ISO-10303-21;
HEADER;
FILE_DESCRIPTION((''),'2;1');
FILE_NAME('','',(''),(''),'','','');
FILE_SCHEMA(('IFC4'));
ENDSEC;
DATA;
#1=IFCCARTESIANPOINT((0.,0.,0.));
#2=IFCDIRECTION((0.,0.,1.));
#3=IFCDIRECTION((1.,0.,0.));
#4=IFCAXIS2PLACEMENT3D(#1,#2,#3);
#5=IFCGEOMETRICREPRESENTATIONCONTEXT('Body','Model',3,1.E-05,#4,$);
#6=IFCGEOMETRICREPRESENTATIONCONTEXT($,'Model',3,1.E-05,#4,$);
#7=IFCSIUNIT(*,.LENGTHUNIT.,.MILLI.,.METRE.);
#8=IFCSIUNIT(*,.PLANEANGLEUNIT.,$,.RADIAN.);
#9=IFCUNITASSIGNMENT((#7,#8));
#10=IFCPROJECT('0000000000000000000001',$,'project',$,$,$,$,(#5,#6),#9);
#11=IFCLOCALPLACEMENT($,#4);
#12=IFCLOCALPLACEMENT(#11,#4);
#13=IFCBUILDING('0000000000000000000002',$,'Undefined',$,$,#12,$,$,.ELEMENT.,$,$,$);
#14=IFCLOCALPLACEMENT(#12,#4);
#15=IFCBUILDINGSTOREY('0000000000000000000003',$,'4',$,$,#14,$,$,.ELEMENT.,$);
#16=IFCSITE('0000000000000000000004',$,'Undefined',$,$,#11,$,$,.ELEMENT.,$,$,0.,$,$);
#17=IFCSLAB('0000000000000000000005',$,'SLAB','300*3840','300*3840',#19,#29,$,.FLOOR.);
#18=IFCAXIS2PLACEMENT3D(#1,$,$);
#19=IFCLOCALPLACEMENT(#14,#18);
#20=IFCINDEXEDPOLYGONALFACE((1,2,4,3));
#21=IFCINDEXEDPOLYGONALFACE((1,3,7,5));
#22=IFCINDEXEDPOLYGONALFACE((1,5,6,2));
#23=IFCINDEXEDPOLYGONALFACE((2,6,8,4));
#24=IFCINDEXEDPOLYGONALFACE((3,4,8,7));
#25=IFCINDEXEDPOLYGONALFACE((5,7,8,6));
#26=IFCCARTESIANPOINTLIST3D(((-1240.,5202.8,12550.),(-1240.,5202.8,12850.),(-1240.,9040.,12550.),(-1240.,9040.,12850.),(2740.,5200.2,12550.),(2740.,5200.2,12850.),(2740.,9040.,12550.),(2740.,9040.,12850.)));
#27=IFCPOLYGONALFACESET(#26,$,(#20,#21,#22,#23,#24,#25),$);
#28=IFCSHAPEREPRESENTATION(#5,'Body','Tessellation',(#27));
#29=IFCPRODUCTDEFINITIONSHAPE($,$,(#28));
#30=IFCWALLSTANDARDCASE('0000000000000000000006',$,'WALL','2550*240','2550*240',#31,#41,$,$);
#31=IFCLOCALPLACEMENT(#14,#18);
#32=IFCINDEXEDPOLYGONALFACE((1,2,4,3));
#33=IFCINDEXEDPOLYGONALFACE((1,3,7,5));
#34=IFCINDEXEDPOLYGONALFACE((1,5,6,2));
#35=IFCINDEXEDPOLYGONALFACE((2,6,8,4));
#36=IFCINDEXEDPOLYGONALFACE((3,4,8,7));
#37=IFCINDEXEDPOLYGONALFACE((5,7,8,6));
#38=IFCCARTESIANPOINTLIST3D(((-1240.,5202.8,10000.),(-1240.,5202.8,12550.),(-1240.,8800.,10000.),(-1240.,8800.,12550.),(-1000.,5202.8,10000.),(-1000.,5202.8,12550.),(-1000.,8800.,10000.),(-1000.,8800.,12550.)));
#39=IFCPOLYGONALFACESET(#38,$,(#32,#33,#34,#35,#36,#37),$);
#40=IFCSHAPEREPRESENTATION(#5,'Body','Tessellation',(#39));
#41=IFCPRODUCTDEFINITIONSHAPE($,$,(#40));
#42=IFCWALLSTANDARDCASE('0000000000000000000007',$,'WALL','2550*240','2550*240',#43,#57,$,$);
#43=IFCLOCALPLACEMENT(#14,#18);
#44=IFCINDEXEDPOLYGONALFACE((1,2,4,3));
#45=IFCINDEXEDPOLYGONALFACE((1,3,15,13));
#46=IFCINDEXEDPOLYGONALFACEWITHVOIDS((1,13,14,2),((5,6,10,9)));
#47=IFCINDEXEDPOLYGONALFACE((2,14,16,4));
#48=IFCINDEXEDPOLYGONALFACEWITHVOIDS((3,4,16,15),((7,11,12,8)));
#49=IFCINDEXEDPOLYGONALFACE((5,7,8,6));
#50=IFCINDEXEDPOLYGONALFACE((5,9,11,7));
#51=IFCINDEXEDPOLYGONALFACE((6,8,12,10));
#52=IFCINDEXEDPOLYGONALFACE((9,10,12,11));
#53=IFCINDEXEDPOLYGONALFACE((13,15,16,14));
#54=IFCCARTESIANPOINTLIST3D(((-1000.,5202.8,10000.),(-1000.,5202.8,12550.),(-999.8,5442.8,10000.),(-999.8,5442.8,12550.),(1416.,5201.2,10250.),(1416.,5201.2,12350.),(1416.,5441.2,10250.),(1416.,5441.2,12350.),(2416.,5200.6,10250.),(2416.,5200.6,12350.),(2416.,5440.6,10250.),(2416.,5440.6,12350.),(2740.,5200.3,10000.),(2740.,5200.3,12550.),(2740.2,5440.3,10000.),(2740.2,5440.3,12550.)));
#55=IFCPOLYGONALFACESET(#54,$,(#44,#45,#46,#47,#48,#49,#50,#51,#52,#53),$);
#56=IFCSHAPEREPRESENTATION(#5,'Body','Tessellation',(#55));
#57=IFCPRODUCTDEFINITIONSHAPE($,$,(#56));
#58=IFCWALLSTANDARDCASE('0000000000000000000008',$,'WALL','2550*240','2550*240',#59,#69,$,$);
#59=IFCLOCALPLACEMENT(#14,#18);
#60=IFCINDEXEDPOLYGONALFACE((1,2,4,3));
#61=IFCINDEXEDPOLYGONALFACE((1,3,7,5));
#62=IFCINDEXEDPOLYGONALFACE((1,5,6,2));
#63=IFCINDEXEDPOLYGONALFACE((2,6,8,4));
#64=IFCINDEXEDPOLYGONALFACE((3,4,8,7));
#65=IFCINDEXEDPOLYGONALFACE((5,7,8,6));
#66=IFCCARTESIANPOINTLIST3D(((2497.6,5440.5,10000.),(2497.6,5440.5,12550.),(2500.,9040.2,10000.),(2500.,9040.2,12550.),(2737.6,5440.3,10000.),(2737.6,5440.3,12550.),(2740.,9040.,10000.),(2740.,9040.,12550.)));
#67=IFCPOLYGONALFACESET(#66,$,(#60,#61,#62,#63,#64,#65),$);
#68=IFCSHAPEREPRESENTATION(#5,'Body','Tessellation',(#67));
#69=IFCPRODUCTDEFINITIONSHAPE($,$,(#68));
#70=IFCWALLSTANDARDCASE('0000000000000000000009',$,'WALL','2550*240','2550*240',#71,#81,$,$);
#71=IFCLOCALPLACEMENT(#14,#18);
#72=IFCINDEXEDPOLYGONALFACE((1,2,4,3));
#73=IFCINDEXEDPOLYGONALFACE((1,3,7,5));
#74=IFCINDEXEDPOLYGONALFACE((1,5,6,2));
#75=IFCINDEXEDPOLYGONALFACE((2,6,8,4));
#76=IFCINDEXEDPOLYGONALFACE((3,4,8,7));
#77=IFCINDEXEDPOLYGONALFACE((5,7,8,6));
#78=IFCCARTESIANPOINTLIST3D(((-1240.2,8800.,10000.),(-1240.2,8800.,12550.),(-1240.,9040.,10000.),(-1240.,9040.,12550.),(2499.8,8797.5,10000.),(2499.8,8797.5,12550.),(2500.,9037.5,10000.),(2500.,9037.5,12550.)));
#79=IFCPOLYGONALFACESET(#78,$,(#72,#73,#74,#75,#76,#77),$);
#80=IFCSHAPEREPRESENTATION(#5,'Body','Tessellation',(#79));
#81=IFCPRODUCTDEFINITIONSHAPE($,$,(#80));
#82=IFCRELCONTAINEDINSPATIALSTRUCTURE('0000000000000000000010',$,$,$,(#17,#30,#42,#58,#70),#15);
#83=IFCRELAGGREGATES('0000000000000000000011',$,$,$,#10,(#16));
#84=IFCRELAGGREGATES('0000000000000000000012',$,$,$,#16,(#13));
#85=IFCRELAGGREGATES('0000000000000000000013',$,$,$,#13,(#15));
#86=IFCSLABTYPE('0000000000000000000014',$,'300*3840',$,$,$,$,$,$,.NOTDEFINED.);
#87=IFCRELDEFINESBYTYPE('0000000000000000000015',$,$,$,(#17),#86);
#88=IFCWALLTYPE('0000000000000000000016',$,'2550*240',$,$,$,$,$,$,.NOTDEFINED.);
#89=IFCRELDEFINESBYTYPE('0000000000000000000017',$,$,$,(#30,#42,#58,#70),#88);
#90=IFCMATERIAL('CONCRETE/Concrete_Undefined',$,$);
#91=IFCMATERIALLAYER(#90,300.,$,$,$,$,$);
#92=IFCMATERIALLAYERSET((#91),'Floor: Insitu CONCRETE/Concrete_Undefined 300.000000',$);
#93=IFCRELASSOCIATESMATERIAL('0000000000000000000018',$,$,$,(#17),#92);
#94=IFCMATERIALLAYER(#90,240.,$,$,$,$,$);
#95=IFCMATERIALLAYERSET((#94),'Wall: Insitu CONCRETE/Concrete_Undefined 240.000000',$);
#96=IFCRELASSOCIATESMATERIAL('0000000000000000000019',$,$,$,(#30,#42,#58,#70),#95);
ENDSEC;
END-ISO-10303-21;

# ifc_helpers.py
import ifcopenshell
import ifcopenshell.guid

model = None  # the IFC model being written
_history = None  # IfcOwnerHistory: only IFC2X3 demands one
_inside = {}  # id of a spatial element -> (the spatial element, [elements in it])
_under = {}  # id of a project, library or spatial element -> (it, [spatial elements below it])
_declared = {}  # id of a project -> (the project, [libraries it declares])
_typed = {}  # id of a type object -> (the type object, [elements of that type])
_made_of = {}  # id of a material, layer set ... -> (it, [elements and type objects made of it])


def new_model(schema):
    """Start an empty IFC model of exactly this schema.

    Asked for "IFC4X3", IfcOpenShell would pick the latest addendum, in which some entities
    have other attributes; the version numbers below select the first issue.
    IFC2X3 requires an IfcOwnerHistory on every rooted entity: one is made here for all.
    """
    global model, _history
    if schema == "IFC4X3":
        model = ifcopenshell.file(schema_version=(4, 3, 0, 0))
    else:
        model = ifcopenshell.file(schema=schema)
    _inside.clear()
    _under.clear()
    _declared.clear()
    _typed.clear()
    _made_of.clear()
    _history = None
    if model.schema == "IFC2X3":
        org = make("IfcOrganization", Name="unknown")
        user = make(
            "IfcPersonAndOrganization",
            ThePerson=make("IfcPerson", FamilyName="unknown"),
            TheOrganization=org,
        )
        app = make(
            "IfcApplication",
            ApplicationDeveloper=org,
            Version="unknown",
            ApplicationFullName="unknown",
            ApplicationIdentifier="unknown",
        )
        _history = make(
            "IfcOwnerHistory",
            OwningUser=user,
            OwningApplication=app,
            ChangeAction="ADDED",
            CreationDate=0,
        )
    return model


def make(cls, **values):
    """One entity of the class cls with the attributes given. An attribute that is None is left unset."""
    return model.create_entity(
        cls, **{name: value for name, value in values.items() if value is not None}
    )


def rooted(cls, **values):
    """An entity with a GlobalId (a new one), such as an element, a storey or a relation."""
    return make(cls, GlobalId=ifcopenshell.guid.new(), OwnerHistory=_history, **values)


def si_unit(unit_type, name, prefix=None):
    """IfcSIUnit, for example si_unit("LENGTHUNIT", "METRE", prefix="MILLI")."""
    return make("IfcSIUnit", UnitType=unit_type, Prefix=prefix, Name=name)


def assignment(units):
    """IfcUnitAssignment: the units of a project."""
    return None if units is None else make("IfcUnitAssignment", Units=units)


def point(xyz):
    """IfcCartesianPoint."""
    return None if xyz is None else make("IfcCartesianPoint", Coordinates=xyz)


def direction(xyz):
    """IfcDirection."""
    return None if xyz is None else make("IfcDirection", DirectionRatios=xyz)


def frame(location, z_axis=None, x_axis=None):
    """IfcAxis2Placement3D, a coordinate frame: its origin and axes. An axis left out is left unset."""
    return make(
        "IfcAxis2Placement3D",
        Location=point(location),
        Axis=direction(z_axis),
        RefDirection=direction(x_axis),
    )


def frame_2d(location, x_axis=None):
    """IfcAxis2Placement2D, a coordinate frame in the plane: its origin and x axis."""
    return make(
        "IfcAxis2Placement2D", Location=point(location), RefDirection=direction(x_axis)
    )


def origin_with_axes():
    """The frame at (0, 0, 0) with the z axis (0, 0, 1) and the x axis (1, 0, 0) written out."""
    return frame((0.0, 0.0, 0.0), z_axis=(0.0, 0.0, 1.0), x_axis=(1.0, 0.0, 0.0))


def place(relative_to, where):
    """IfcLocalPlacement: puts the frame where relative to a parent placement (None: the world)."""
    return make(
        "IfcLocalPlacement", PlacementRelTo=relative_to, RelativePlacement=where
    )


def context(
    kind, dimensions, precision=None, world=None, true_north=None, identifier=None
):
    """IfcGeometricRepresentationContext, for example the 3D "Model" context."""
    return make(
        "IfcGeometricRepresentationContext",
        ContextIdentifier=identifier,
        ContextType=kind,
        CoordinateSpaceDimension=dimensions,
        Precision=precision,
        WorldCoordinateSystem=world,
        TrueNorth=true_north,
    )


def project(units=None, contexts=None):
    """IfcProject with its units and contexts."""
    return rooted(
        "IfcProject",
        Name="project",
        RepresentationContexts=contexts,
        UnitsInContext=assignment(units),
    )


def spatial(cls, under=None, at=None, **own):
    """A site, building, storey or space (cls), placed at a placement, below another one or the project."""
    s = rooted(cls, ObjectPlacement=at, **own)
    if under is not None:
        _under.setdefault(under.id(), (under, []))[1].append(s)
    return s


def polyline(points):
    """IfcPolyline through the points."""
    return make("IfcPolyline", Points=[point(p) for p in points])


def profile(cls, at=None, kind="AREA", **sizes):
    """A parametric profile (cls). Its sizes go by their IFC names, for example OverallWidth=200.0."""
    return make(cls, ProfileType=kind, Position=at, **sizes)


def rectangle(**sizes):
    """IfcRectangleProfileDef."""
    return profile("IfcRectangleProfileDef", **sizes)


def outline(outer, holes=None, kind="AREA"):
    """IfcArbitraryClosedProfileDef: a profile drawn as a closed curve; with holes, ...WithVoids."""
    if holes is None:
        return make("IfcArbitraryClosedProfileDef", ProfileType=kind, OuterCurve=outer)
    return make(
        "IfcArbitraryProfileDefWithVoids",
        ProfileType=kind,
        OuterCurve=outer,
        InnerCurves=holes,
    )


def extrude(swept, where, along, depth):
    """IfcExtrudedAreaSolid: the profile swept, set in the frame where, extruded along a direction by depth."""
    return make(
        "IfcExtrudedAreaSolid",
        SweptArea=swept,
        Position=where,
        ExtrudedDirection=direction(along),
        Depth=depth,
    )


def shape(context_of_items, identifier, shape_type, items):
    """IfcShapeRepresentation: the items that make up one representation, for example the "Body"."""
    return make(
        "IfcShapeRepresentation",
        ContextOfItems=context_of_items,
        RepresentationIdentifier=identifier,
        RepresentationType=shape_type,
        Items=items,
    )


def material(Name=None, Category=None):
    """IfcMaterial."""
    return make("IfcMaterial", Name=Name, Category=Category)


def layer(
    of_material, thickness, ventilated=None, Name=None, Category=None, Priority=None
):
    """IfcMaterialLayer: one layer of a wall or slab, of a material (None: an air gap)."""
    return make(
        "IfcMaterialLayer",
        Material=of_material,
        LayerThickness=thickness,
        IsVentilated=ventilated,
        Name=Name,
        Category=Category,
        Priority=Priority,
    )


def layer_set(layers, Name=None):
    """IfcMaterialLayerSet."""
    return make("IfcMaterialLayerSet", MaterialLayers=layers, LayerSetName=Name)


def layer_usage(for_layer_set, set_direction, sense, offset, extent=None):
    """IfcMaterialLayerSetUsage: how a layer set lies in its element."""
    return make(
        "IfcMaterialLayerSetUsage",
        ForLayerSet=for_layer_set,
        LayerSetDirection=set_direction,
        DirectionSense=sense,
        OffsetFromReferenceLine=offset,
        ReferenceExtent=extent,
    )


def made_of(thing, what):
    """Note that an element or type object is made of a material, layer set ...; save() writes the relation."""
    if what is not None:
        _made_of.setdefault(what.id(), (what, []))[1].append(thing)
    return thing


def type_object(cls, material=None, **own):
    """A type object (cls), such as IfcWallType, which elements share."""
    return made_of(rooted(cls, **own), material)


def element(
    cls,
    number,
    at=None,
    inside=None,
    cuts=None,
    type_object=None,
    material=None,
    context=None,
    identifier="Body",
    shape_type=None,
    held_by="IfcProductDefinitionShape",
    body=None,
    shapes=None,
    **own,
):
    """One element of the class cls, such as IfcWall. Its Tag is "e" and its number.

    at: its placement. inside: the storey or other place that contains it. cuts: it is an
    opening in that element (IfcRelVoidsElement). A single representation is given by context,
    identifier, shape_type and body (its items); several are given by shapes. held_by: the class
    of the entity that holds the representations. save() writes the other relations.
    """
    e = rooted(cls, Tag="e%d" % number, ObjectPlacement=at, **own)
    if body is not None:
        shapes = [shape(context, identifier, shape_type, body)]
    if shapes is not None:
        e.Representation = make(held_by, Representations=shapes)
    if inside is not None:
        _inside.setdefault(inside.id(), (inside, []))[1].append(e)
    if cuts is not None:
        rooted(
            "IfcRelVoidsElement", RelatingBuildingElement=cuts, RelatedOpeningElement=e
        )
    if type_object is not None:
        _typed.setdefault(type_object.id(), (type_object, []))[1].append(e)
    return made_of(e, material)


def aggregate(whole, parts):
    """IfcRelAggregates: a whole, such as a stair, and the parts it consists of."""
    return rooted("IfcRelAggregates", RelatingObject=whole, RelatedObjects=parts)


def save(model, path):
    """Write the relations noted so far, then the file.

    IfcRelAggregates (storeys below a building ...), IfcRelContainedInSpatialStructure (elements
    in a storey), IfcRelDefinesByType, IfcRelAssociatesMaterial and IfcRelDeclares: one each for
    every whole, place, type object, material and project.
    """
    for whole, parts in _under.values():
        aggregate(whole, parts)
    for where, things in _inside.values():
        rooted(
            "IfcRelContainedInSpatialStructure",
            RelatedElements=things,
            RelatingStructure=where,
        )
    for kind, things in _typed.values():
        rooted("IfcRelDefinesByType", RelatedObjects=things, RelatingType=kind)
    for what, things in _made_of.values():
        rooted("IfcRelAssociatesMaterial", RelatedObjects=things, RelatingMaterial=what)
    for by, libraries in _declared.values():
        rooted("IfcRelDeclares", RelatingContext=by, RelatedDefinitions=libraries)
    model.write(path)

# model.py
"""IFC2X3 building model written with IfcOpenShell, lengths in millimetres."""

from ifc_helpers import new_model, si_unit, frame, frame_2d, origin_with_axes, place, context, project, spatial, polyline, rectangle, outline, extrude, material, layer, layer_set, layer_usage, type_object, element, save


model = new_model("IFC2X3")

# Units and contexts
model_context_1 = context("Model", 3, precision=1e-05, world=origin_with_axes(), identifier="Body")
model_context_2 = context("Model", 3, precision=1e-05, world=origin_with_axes())
ifc_project = project(units=[si_unit("LENGTHUNIT", "METRE", prefix="MILLI"), si_unit("PLANEANGLEUNIT", "RADIAN")], contexts=[model_context_1, model_context_2])

# Site, building, storey
site_placement = place(None, origin_with_axes())
site = spatial("IfcSite", under=ifc_project, at=site_placement, Name="Undefined", CompositionType="ELEMENT", RefElevation=0.0)
building_placement = place(site_placement, origin_with_axes())
building = spatial("IfcBuilding", under=site, at=building_placement, Name="Undefined", CompositionType="ELEMENT")
storey_placement = place(building_placement, origin_with_axes())
storey = spatial("IfcBuildingStorey", under=building, at=storey_placement, Name="4", CompositionType="ELEMENT")

# Slab
ifc_material = material(Name="CONCRETE/Concrete_Undefined")
ifc_layer_1 = layer(ifc_material, 300.0)
ifc_layer_set_1 = layer_set([ifc_layer_1], Name="Floor: Insitu CONCRETE/Concrete_Undefined 300.000000")
ifc_layer_usage_1 = layer_usage(ifc_layer_set_1, "AXIS3", "POSITIVE", -150.0)
slab_type = type_object("IfcSlabType", Name="300*3840", PredefinedType="NOTDEFINED")
slab_placement = place(storey_placement, frame((-1240.0, 9040.0, 12700.0), z_axis=(0.0, 0.0, 1.0), x_axis=(0.0, -1.0, 0.0)))
element("IfcSlab", 1, at=slab_placement, inside=storey, type_object=slab_type, material=ifc_layer_usage_1, Name="SLAB", Description="300*3840", ObjectType="300*3840", PredefinedType="FLOOR", context=model_context_1, shape_type="SweptSolid", body=[
    extrude(outline(polyline([(0.0, 0.0), (3837.2, 0.0), (3839.8, 3980.0), (0.0, 3980.0), (0.0, 0.0)])), frame((0.0, 0.0, -150.0), z_axis=(0.0, 0.0, 1.0), x_axis=(1.0, 0.0, 0.0)), (0.0, 0.0, 1.0), 300.0),
])

# Wall
ifc_layer_2 = layer(ifc_material, 240.0)
ifc_layer_set_2 = layer_set([ifc_layer_2], Name="Wall: Insitu CONCRETE/Concrete_Undefined 240.000000")
ifc_layer_usage_2 = layer_usage(ifc_layer_set_2, "AXIS2", "POSITIVE", -120.0)
wall_type = type_object("IfcWallType", Name="2550*240", PredefinedType="NOTDEFINED")
wall_1_placement = place(storey_placement, frame((-1120.0, 5202.8, 10000.0), z_axis=(0.0, 0.0, 1.0), x_axis=(0.0, 1.0, 0.0)))
element("IfcWallStandardCase", 2, at=wall_1_placement, inside=storey, type_object=wall_type, material=ifc_layer_usage_2, Name="WALL", Description="2550*240", ObjectType="2550*240", context=model_context_1, shape_type="SweptSolid", body=[
    extrude(rectangle(XDim=3597.2, YDim=240.0, at=frame_2d((0.0, 1798.6), x_axis=(0.0, -1.0))), frame((0.0, 0.0, 0.0), z_axis=(0.0, 0.0, 1.0), x_axis=(0.0, -1.0, 0.0)), (0.0, 0.0, 1.0), 2550.0),
])

# Wall, opening
ifc_layer_usage_3 = layer_usage(ifc_layer_set_2, "AXIS2", "POSITIVE", -120.0)
wall_2_placement = place(storey_placement, frame((2740.1, 5320.3, 10000.0), z_axis=(0.0, 0.0, 1.0), x_axis=(-1.0, 0.000671, 0.0)))
wall_2 = element("IfcWallStandardCase", 3, at=wall_2_placement, inside=storey, type_object=wall_type, material=ifc_layer_usage_3, Name="WALL", Description="2550*240", ObjectType="2550*240", context=model_context_1, shape_type="SweptSolid", body=[
    extrude(rectangle(XDim=3740.0, YDim=240.0, at=frame_2d((0.0, 1870.0), x_axis=(0.0, -1.0))), frame((0.0, 0.0, 0.0), z_axis=(0.0, 0.0, 1.0), x_axis=(0.0, -1.0, 0.0)), (0.0, 0.0, 1.0), 2550.0),
])
opening_placement = place(storey_placement, frame((2740.1, 5320.3, 10000.0), z_axis=(0.0, 0.0, 1.0), x_axis=(-1.0, 0.000671, 0.0)))
element("IfcOpeningElement", 4, at=opening_placement, cuts=wall_2, ObjectType="Recess", context=model_context_1, shape_type="SweptSolid", body=[
    extrude(outline(polyline([(0.0, 0.0), (2100.0, 0.0), (2100.0, 1000.0), (0.0, 1000.0), (0.0, 0.0)])), frame((1324.1, -124.4, 2350.0), z_axis=(-0.000671, 1.0, 0.0), x_axis=(0.0, 0.0, -1.0)), (0.0, 0.0, 1.0), 248.0),
])

# Walls
ifc_layer_usage_4 = layer_usage(ifc_layer_set_2, "AXIS2", "POSITIVE", -120.0)
wall_3_placement = place(storey_placement, frame((2620.0, 9040.1, 10000.0), z_axis=(0.0, 0.0, 1.0), x_axis=(-0.000671, -1.0, 0.0)))
element("IfcWallStandardCase", 5, at=wall_3_placement, inside=storey, type_object=wall_type, material=ifc_layer_usage_4, Name="WALL", Description="2550*240", ObjectType="2550*240", context=model_context_1, shape_type="SweptSolid", body=[
    extrude(rectangle(XDim=3599.7, YDim=240.0, at=frame_2d((0.0, 1799.8), x_axis=(0.0, -1.0))), frame((0.0, 0.0, 0.0), z_axis=(0.0, 0.0, 1.0), x_axis=(0.0, -1.0, 0.0)), (0.0, 0.0, 1.0), 2550.0),
])
ifc_layer_usage_5 = layer_usage(ifc_layer_set_2, "AXIS2", "POSITIVE", -120.0)
wall_4_placement = place(storey_placement, frame((-1240.1, 8920.0, 10000.0), z_axis=(0.0, 0.0, 1.0), x_axis=(1.0, -0.000671, 0.0)))
element("IfcWallStandardCase", 6, at=wall_4_placement, inside=storey, type_object=wall_type, material=ifc_layer_usage_5, Name="WALL", Description="2550*240", ObjectType="2550*240", context=model_context_1, shape_type="SweptSolid", body=[
    extrude(rectangle(XDim=3740.0, YDim=240.0, at=frame_2d((0.0, 1870.0), x_axis=(0.0, -1.0))), frame((0.0, 0.0, 0.0), z_axis=(0.0, 0.0, 1.0), x_axis=(0.0, -1.0, 0.0)), (0.0, 0.0, 1.0), 2550.0),
])

save(model, "model.ifc")
